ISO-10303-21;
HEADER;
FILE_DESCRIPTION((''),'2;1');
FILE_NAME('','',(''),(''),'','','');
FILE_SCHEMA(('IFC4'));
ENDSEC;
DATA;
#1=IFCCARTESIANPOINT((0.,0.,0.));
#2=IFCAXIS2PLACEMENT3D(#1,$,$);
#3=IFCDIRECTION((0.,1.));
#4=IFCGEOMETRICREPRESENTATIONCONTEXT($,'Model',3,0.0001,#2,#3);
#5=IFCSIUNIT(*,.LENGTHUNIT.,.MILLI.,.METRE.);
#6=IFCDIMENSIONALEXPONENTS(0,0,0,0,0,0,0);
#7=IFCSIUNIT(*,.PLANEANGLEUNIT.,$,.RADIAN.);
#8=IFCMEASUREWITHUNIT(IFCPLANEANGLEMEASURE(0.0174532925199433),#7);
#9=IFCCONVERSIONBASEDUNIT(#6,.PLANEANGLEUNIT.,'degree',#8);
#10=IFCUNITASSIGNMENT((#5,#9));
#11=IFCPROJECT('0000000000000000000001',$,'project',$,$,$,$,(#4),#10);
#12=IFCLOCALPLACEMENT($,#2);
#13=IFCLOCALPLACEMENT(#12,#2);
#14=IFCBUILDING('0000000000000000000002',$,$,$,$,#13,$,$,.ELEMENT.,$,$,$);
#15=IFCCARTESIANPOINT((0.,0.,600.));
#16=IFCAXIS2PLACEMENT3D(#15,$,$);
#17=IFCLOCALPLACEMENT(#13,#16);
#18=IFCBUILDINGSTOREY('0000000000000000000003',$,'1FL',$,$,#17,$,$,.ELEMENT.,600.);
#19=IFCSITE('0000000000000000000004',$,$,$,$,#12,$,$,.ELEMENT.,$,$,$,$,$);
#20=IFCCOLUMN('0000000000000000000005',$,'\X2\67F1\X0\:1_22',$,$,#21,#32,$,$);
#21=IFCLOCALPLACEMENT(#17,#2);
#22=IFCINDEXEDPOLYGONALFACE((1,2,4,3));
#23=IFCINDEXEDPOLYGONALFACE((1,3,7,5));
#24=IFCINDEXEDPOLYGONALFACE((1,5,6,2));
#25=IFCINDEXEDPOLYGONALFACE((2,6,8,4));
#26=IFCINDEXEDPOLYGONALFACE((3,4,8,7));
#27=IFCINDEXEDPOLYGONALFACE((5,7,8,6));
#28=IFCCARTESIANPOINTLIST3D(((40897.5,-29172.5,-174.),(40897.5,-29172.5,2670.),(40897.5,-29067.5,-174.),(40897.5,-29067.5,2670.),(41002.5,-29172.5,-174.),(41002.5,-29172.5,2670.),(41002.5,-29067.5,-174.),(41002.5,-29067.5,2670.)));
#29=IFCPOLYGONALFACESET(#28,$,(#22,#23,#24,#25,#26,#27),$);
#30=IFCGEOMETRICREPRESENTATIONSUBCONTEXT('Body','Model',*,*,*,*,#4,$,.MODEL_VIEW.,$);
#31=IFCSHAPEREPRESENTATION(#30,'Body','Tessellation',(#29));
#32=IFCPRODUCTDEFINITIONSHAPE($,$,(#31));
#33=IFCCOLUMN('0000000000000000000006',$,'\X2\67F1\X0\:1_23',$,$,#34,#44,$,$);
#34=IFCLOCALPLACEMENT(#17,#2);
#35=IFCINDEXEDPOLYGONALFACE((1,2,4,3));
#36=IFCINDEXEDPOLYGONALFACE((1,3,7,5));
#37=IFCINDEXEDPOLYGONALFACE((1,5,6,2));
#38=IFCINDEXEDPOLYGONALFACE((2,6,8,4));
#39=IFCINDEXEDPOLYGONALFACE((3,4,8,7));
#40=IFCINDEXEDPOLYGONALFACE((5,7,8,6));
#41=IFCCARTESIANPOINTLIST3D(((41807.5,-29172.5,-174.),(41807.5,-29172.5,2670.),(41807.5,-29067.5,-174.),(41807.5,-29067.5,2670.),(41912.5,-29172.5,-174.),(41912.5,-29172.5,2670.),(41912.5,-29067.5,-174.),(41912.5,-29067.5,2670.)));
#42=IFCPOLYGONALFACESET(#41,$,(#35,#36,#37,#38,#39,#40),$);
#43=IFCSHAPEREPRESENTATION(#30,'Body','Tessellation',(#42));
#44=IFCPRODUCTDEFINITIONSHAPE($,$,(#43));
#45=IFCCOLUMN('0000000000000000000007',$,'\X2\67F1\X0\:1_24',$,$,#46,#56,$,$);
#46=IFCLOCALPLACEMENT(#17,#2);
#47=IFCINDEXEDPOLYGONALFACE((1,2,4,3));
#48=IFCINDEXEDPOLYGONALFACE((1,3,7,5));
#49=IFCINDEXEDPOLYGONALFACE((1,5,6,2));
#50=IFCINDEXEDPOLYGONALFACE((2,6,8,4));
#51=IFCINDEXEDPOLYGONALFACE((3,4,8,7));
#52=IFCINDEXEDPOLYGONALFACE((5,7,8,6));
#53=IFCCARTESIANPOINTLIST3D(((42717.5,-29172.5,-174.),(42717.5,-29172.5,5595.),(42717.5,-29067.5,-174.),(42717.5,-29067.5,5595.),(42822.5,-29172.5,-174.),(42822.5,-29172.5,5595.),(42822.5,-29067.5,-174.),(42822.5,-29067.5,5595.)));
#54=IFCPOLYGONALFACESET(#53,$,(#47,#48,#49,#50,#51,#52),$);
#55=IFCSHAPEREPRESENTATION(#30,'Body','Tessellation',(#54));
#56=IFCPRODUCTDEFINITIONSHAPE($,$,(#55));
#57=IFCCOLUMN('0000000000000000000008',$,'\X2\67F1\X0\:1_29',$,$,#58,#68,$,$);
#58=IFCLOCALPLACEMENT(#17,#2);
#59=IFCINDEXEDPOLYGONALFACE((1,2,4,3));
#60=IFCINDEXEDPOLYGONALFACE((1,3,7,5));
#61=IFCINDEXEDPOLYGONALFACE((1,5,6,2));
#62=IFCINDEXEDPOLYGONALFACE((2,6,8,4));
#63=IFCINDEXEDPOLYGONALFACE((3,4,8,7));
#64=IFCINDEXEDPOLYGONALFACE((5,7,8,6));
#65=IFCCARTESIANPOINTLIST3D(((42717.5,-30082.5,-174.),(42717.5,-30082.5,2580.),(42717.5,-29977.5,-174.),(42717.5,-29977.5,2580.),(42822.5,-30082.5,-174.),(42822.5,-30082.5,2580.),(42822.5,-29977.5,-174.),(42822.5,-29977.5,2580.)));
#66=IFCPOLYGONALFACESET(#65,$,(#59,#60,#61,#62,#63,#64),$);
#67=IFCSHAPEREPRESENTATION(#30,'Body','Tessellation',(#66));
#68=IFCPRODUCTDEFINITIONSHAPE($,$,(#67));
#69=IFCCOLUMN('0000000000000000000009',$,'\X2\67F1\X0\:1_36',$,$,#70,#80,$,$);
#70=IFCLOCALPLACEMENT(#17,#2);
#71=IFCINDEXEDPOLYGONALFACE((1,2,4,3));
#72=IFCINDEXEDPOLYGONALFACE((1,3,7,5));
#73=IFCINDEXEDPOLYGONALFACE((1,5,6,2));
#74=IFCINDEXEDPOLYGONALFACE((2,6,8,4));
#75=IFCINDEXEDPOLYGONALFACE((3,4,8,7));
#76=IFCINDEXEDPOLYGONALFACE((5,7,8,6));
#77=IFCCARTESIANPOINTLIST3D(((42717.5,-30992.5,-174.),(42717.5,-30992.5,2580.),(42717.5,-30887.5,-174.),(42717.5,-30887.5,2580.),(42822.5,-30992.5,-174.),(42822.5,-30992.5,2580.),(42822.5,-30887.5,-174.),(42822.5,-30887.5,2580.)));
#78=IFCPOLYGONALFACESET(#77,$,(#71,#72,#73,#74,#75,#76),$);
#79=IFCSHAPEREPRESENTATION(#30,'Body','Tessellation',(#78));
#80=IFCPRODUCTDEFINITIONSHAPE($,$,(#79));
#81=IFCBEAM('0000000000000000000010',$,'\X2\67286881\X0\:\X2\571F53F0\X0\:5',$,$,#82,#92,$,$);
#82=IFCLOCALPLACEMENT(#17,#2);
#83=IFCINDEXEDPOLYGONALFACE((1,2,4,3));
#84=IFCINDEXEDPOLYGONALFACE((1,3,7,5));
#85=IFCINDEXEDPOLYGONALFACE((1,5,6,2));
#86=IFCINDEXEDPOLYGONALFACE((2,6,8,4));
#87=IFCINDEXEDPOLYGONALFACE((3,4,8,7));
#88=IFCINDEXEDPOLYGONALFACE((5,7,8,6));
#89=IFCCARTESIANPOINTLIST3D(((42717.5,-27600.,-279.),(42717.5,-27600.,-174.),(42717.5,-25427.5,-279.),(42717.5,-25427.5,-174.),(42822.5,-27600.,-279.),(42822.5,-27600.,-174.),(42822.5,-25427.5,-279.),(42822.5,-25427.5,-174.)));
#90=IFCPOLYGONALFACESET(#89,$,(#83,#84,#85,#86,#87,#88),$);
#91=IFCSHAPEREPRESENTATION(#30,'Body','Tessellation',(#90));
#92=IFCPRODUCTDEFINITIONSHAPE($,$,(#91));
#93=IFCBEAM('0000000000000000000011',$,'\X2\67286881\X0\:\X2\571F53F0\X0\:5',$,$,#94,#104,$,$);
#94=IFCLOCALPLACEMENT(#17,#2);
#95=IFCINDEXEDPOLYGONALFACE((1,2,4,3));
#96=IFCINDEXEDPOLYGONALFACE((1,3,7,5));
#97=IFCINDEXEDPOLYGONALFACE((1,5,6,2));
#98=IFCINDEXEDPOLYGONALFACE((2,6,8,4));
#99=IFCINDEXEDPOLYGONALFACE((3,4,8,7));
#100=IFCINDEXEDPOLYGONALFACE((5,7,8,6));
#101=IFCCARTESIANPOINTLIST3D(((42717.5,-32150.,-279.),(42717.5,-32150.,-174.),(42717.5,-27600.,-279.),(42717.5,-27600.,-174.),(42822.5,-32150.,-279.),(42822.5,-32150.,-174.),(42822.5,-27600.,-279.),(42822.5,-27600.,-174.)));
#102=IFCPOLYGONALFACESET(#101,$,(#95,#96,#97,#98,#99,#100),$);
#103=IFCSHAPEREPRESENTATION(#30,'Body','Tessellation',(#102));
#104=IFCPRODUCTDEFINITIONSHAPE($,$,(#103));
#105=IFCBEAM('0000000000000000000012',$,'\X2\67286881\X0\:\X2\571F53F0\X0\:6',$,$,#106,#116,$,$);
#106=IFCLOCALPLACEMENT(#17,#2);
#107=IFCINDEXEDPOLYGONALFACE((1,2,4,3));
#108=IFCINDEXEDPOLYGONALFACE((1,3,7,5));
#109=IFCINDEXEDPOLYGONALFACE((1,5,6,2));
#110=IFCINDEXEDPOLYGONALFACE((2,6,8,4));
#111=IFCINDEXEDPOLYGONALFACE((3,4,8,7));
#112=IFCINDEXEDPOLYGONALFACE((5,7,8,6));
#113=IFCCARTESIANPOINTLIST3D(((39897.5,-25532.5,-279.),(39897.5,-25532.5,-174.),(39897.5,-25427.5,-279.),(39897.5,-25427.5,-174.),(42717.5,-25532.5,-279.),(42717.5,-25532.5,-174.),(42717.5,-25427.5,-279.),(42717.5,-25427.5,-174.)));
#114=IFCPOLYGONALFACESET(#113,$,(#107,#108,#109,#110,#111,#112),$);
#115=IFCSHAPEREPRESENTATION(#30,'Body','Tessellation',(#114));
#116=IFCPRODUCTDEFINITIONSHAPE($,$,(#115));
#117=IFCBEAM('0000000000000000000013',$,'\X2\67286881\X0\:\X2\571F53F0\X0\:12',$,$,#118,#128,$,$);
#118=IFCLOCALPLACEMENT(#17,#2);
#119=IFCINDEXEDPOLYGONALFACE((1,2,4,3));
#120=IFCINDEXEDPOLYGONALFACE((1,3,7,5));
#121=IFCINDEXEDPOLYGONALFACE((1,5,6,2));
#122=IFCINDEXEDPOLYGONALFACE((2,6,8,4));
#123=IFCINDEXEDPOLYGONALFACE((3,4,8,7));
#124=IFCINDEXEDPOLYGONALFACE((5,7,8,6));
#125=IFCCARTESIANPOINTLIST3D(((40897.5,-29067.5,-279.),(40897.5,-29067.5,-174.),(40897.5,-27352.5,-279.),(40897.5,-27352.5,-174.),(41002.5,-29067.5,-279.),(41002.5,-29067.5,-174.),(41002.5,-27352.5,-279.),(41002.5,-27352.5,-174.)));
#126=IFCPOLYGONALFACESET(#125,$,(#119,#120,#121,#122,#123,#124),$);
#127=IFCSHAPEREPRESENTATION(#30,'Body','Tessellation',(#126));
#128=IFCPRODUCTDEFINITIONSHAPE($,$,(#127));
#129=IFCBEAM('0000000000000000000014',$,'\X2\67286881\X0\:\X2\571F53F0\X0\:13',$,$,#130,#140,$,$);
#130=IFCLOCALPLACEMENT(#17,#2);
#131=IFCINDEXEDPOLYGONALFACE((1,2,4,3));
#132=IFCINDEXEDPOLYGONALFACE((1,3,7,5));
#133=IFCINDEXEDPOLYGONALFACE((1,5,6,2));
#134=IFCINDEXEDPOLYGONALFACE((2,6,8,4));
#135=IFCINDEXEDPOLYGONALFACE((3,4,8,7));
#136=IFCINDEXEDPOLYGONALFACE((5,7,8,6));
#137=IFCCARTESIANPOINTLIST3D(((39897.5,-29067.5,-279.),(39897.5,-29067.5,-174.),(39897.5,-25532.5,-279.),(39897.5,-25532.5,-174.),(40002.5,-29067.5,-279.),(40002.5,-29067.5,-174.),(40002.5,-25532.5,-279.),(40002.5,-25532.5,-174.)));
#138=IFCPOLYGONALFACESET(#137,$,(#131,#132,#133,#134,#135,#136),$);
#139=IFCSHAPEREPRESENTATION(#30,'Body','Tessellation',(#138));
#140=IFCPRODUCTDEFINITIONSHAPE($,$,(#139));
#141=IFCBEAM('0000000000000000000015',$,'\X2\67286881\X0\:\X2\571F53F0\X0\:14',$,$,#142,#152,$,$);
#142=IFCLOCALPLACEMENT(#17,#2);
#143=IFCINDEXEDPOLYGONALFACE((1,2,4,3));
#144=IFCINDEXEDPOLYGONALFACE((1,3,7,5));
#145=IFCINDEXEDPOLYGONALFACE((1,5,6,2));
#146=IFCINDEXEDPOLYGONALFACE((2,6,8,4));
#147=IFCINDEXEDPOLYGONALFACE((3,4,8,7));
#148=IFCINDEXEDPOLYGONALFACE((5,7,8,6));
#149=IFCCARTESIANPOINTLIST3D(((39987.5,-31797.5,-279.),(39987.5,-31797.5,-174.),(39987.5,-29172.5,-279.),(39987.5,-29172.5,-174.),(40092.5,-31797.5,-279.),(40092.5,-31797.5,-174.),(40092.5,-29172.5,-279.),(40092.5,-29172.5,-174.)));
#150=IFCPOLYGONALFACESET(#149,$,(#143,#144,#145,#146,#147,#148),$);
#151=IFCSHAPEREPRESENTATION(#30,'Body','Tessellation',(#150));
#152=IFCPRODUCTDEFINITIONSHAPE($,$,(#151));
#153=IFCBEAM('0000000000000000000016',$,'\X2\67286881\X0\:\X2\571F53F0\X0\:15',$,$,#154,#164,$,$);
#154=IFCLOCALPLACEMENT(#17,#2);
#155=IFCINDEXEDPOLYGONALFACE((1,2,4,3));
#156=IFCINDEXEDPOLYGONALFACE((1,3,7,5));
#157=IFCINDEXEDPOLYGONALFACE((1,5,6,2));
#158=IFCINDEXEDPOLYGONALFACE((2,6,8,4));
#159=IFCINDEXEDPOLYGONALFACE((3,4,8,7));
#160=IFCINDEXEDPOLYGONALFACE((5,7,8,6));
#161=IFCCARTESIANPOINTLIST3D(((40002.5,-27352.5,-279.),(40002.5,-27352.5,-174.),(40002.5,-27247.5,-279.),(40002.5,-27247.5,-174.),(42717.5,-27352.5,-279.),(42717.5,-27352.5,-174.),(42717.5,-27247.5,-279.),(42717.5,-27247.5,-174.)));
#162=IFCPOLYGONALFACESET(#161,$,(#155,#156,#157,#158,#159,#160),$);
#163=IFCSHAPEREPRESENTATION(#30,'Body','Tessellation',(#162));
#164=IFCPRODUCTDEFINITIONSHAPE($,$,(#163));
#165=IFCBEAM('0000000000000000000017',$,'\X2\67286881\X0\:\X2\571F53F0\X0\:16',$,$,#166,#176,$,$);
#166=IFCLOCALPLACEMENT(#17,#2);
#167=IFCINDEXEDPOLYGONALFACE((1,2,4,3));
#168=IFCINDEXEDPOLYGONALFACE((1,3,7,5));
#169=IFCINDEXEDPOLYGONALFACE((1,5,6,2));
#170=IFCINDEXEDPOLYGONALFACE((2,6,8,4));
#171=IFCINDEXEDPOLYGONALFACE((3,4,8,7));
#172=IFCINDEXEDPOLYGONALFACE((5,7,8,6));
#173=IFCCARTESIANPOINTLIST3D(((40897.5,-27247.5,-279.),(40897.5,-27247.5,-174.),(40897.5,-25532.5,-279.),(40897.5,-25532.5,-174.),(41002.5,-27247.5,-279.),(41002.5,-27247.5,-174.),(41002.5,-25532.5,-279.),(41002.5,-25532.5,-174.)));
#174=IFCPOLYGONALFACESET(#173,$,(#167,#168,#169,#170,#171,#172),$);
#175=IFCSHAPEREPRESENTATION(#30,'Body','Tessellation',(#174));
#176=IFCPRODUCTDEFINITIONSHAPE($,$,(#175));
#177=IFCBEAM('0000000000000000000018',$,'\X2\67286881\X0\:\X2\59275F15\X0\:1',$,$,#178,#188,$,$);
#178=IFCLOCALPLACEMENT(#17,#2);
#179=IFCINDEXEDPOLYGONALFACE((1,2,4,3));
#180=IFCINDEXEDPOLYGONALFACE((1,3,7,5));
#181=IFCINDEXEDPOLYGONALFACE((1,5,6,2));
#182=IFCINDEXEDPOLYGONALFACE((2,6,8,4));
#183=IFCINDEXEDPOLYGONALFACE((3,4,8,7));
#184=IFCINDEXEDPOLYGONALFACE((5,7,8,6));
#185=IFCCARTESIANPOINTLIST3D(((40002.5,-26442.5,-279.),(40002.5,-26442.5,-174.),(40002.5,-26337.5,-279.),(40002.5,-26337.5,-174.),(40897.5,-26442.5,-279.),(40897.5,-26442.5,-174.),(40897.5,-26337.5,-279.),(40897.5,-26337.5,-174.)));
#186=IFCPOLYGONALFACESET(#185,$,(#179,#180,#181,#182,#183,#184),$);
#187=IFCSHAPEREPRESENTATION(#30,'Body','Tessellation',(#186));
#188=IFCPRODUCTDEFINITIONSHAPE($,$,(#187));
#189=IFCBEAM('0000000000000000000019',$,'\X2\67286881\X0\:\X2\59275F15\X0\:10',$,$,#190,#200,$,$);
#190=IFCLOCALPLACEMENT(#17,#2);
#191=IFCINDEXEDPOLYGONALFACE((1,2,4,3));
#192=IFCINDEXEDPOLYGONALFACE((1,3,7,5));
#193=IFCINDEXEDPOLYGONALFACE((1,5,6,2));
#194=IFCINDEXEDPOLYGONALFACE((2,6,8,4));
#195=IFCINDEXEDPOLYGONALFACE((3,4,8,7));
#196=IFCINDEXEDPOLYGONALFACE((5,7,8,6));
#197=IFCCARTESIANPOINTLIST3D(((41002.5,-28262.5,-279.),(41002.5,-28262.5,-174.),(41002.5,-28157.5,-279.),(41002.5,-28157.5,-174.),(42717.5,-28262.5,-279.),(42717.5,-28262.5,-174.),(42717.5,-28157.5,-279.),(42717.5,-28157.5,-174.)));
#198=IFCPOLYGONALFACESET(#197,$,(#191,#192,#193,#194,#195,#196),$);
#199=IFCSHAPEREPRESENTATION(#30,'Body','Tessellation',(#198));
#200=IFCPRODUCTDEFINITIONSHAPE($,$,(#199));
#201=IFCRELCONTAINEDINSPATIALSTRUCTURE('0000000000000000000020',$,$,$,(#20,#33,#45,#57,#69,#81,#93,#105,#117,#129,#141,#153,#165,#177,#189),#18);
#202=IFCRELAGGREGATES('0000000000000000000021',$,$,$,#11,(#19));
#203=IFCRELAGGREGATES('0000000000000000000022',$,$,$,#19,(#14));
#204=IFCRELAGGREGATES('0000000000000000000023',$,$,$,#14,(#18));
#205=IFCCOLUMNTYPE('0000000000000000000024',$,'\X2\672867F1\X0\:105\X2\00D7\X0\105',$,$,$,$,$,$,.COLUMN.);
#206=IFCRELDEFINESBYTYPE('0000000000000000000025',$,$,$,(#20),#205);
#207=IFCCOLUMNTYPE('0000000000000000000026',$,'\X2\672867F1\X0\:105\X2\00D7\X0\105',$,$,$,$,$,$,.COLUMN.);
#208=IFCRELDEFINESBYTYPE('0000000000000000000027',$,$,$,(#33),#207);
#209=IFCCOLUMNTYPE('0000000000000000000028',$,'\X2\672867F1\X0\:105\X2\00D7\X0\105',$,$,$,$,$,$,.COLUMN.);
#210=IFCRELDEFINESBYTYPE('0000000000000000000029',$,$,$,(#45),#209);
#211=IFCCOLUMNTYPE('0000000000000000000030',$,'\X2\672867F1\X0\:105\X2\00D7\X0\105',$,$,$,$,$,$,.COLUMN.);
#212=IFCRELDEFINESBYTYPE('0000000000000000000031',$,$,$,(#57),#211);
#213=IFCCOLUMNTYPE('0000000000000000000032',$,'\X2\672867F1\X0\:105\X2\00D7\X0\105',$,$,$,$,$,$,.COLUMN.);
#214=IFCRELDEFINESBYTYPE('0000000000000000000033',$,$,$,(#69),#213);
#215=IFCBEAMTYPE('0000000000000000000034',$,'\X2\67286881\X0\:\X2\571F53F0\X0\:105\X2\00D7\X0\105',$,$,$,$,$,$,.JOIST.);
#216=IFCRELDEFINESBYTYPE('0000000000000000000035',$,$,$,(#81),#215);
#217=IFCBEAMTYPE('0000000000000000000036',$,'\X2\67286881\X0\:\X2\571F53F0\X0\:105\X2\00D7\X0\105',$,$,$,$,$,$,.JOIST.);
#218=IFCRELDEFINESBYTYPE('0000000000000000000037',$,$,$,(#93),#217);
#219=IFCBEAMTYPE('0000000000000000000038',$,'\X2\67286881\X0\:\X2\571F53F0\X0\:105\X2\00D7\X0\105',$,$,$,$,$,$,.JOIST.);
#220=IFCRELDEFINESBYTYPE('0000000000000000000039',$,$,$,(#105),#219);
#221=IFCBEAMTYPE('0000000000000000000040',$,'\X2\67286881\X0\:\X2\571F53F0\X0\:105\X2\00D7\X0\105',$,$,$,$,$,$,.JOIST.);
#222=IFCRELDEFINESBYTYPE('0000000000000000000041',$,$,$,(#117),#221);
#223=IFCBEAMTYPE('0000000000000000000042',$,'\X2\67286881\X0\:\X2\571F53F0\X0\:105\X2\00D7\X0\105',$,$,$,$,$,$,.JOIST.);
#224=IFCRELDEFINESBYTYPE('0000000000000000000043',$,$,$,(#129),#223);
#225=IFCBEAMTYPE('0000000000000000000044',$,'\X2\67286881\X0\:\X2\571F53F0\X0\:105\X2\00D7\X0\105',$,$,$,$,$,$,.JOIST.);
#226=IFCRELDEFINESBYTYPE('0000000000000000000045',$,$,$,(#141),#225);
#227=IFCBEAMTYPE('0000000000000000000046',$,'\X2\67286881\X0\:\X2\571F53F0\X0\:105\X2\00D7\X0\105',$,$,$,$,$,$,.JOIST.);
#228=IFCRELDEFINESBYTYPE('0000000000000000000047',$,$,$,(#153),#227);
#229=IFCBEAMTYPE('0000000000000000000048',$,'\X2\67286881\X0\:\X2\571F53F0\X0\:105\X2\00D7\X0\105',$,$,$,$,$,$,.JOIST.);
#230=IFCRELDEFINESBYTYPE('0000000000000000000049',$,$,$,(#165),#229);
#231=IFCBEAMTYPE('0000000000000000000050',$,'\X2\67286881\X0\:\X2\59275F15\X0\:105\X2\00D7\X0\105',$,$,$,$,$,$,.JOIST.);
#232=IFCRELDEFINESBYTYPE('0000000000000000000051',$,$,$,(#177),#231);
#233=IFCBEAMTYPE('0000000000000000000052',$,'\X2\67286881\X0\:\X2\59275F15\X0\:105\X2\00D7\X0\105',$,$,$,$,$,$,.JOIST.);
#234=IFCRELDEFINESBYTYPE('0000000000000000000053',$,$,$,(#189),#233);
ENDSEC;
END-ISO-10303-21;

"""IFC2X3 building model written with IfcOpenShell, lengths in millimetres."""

from ifc_helpers import new_model, entity, si_unit, converted_unit, direction, frame, origin, origin_with_axes, origin_2d, place, context, subcontext, project, spatial, rectangle, extrude, type_object, element, save


model = new_model("IFC2X3")

# Units and contexts
model_context = context("Model", 3, precision=0.0001, world=origin(), true_north=direction((0.0, 1.0)))
body_context = subcontext(model_context, "Body", "Model", "MODEL_VIEW")
ifc_project = project(units=[si_unit("LENGTHUNIT", "METRE", prefix="MILLI"), converted_unit("PLANEANGLEUNIT", "degree", entity("IfcPlaneAngleMeasure", 0.0174532925199433), si_unit("PLANEANGLEUNIT", "RADIAN"), dimensions=[0, 0, 0, 0, 0, 0, 0])], contexts=[model_context])

# Site, building, storey
site_placement = place(None, origin())
site = spatial("IfcSite", under=ifc_project, at=site_placement, CompositionType="ELEMENT")
building_placement = place(site_placement, origin())
building = spatial("IfcBuilding", under=site, at=building_placement, CompositionType="ELEMENT")
storey_placement = place(building_placement, frame((0.0, 0.0, 600.0)))
storey = spatial("IfcBuildingStorey", under=building, at=storey_placement, Name="1FL", CompositionType="ELEMENT", Elevation=600.0)

# Columns
column_type_1 = type_object("IfcColumnType", Name="木柱:105×105", PredefinedType="COLUMN")
column_1_placement = place(storey_placement, frame((40950.0, -29120.0, -174.0)))
element("IfcColumn", 1, at=column_1_placement, inside=storey, type_object=column_type_1, Name="柱:1_22", context=body_context, shape_type="SweptSolid", body=[
    extrude(rectangle(XDim=105.0, YDim=105.0, at=origin_2d()), origin_with_axes(), (0.0, 0.0, 1.0), 2844.0),
])
column_type_2 = type_object("IfcColumnType", Name="木柱:105×105", PredefinedType="COLUMN")
column_2_placement = place(storey_placement, frame((41860.0, -29120.0, -174.0)))
element("IfcColumn", 2, at=column_2_placement, inside=storey, type_object=column_type_2, Name="柱:1_23", context=body_context, shape_type="SweptSolid", body=[
    extrude(rectangle(XDim=105.0, YDim=105.0, at=origin_2d()), origin_with_axes(), (0.0, 0.0, 1.0), 2844.0),
])
column_type_3 = type_object("IfcColumnType", Name="木柱:105×105", PredefinedType="COLUMN")
column_3_placement = place(storey_placement, frame((42770.0, -29120.0, -174.0)))
element("IfcColumn", 3, at=column_3_placement, inside=storey, type_object=column_type_3, Name="柱:1_24", context=body_context, shape_type="SweptSolid", body=[
    extrude(rectangle(XDim=105.0, YDim=105.0, at=origin_2d()), origin_with_axes(), (0.0, 0.0, 1.0), 5769.0),
])
column_type_4 = type_object("IfcColumnType", Name="木柱:105×105", PredefinedType="COLUMN")
column_4_placement = place(storey_placement, frame((42770.0, -30030.0, -174.0)))
element("IfcColumn", 4, at=column_4_placement, inside=storey, type_object=column_type_4, Name="柱:1_29", context=body_context, shape_type="SweptSolid", body=[
    extrude(rectangle(XDim=105.0, YDim=105.0, at=origin_2d()), origin_with_axes(), (0.0, 0.0, 1.0), 2754.0),
])
column_type_5 = type_object("IfcColumnType", Name="木柱:105×105", PredefinedType="COLUMN")
column_5_placement = place(storey_placement, frame((42770.0, -30940.0, -174.0)))
element("IfcColumn", 5, at=column_5_placement, inside=storey, type_object=column_type_5, Name="柱:1_36", context=body_context, shape_type="SweptSolid", body=[
    extrude(rectangle(XDim=105.0, YDim=105.0, at=origin_2d()), origin_with_axes(), (0.0, 0.0, 1.0), 2754.0),
])

# Beams
beam_type_1 = type_object("IfcBeamType", Name="木梁:土台:105×105", PredefinedType="JOIST")
beam_1_placement = place(storey_placement, frame((42770.0, -25427.5, -226.5), z_axis=(0.0, -1.0, 0.0), x_axis=(1.0, 0.0, 0.0)))
element("IfcBeam", 6, at=beam_1_placement, inside=storey, type_object=beam_type_1, Name="木梁:土台:5", context=body_context, shape_type="SweptSolid", body=[
    extrude(rectangle(XDim=105.0, YDim=105.0, at=origin_2d()), origin_with_axes(), (0.0, 0.0, 1.0), 2172.5),
])
beam_type_2 = type_object("IfcBeamType", Name="木梁:土台:105×105", PredefinedType="JOIST")
beam_2_placement = place(storey_placement, frame((42770.0, -27600.0, -226.5), z_axis=(0.0, -1.0, 0.0), x_axis=(1.0, 0.0, 0.0)))
element("IfcBeam", 7, at=beam_2_placement, inside=storey, type_object=beam_type_2, Name="木梁:土台:5", context=body_context, shape_type="SweptSolid", body=[
    extrude(rectangle(XDim=105.0, YDim=105.0, at=origin_2d()), origin_with_axes(), (0.0, 0.0, 1.0), 4550.0),
])
beam_type_3 = type_object("IfcBeamType", Name="木梁:土台:105×105", PredefinedType="JOIST")
beam_3_placement = place(storey_placement, frame((39897.5, -25480.0, -226.5), z_axis=(1.0, 0.0, 0.0), x_axis=(0.0, 1.0, 0.0)))
element("IfcBeam", 8, at=beam_3_placement, inside=storey, type_object=beam_type_3, Name="木梁:土台:6", context=body_context, shape_type="SweptSolid", body=[
    extrude(rectangle(XDim=105.0, YDim=105.0, at=origin_2d()), origin_with_axes(), (0.0, 0.0, 1.0), 2820.0),
])
beam_type_4 = type_object("IfcBeamType", Name="木梁:土台:105×105", PredefinedType="JOIST")
beam_4_placement = place(storey_placement, frame((40950.0, -27352.5, -226.5), z_axis=(0.0, -1.0, 0.0), x_axis=(1.0, 0.0, 0.0)))
element("IfcBeam", 9, at=beam_4_placement, inside=storey, type_object=beam_type_4, Name="木梁:土台:12", context=body_context, shape_type="SweptSolid", body=[
    extrude(rectangle(XDim=105.0, YDim=105.0, at=origin_2d()), origin_with_axes(), (0.0, 0.0, 1.0), 1715.0),
])
beam_type_5 = type_object("IfcBeamType", Name="木梁:土台:105×105", PredefinedType="JOIST")
beam_5_placement = place(storey_placement, frame((39950.0, -25532.5, -226.5), z_axis=(0.0, -1.0, 0.0), x_axis=(1.0, 0.0, 0.0)))
element("IfcBeam", 10, at=beam_5_placement, inside=storey, type_object=beam_type_5, Name="木梁:土台:13", context=body_context, shape_type="SweptSolid", body=[
    extrude(rectangle(XDim=105.0, YDim=105.0, at=origin_2d()), origin_with_axes(), (0.0, 0.0, 1.0), 3535.0),
])
beam_type_6 = type_object("IfcBeamType", Name="木梁:土台:105×105", PredefinedType="JOIST")
beam_6_placement = place(storey_placement, frame((40040.0, -29172.5, -226.5), z_axis=(0.0, -1.0, 0.0), x_axis=(1.0, 0.0, 0.0)))
element("IfcBeam", 11, at=beam_6_placement, inside=storey, type_object=beam_type_6, Name="木梁:土台:14", context=body_context, shape_type="SweptSolid", body=[
    extrude(rectangle(XDim=105.0, YDim=105.0, at=origin_2d()), origin_with_axes(), (0.0, 0.0, 1.0), 2625.0),
])
beam_type_7 = type_object("IfcBeamType", Name="木梁:土台:105×105", PredefinedType="JOIST")
beam_7_placement = place(storey_placement, frame((40002.5, -27300.0, -226.5), z_axis=(1.0, 0.0, 0.0), x_axis=(0.0, 1.0, 0.0)))
element("IfcBeam", 12, at=beam_7_placement, inside=storey, type_object=beam_type_7, Name="木梁:土台:15", context=body_context, shape_type="SweptSolid", body=[
    extrude(rectangle(XDim=105.0, YDim=105.0, at=origin_2d()), origin_with_axes(), (0.0, 0.0, 1.0), 2715.0),
])
beam_type_8 = type_object("IfcBeamType", Name="木梁:土台:105×105", PredefinedType="JOIST")
beam_8_placement = place(storey_placement, frame((40950.0, -25532.5, -226.5), z_axis=(0.0, -1.0, 0.0), x_axis=(1.0, 0.0, 0.0)))
element("IfcBeam", 13, at=beam_8_placement, inside=storey, type_object=beam_type_8, Name="木梁:土台:16", context=body_context, shape_type="SweptSolid", body=[
    extrude(rectangle(XDim=105.0, YDim=105.0, at=origin_2d()), origin_with_axes(), (0.0, 0.0, 1.0), 1715.0),
])
beam_type_9 = type_object("IfcBeamType", Name="木梁:大引:105×105", PredefinedType="JOIST")
beam_9_placement = place(storey_placement, frame((40002.5, -26390.0, -226.5), z_axis=(1.0, 0.0, 0.0), x_axis=(0.0, 1.0, 0.0)))
element("IfcBeam", 14, at=beam_9_placement, inside=storey, type_object=beam_type_9, Name="木梁:大引:1", context=body_context, shape_type="SweptSolid", body=[
    extrude(rectangle(XDim=105.0, YDim=105.0, at=origin_2d()), origin_with_axes(), (0.0, 0.0, 1.0), 895.0),
])
beam_type_10 = type_object("IfcBeamType", Name="木梁:大引:105×105", PredefinedType="JOIST")
beam_10_placement = place(storey_placement, frame((41002.5, -28210.0, -226.5), z_axis=(1.0, 0.0, 0.0), x_axis=(0.0, 1.0, 0.0)))
element("IfcBeam", 15, at=beam_10_placement, inside=storey, type_object=beam_type_10, Name="木梁:大引:10", context=body_context, shape_type="SweptSolid", body=[
    extrude(rectangle(XDim=105.0, YDim=105.0, at=origin_2d()), origin_with_axes(), (0.0, 0.0, 1.0), 1715.0),
])

save(model, "model.ifc")
